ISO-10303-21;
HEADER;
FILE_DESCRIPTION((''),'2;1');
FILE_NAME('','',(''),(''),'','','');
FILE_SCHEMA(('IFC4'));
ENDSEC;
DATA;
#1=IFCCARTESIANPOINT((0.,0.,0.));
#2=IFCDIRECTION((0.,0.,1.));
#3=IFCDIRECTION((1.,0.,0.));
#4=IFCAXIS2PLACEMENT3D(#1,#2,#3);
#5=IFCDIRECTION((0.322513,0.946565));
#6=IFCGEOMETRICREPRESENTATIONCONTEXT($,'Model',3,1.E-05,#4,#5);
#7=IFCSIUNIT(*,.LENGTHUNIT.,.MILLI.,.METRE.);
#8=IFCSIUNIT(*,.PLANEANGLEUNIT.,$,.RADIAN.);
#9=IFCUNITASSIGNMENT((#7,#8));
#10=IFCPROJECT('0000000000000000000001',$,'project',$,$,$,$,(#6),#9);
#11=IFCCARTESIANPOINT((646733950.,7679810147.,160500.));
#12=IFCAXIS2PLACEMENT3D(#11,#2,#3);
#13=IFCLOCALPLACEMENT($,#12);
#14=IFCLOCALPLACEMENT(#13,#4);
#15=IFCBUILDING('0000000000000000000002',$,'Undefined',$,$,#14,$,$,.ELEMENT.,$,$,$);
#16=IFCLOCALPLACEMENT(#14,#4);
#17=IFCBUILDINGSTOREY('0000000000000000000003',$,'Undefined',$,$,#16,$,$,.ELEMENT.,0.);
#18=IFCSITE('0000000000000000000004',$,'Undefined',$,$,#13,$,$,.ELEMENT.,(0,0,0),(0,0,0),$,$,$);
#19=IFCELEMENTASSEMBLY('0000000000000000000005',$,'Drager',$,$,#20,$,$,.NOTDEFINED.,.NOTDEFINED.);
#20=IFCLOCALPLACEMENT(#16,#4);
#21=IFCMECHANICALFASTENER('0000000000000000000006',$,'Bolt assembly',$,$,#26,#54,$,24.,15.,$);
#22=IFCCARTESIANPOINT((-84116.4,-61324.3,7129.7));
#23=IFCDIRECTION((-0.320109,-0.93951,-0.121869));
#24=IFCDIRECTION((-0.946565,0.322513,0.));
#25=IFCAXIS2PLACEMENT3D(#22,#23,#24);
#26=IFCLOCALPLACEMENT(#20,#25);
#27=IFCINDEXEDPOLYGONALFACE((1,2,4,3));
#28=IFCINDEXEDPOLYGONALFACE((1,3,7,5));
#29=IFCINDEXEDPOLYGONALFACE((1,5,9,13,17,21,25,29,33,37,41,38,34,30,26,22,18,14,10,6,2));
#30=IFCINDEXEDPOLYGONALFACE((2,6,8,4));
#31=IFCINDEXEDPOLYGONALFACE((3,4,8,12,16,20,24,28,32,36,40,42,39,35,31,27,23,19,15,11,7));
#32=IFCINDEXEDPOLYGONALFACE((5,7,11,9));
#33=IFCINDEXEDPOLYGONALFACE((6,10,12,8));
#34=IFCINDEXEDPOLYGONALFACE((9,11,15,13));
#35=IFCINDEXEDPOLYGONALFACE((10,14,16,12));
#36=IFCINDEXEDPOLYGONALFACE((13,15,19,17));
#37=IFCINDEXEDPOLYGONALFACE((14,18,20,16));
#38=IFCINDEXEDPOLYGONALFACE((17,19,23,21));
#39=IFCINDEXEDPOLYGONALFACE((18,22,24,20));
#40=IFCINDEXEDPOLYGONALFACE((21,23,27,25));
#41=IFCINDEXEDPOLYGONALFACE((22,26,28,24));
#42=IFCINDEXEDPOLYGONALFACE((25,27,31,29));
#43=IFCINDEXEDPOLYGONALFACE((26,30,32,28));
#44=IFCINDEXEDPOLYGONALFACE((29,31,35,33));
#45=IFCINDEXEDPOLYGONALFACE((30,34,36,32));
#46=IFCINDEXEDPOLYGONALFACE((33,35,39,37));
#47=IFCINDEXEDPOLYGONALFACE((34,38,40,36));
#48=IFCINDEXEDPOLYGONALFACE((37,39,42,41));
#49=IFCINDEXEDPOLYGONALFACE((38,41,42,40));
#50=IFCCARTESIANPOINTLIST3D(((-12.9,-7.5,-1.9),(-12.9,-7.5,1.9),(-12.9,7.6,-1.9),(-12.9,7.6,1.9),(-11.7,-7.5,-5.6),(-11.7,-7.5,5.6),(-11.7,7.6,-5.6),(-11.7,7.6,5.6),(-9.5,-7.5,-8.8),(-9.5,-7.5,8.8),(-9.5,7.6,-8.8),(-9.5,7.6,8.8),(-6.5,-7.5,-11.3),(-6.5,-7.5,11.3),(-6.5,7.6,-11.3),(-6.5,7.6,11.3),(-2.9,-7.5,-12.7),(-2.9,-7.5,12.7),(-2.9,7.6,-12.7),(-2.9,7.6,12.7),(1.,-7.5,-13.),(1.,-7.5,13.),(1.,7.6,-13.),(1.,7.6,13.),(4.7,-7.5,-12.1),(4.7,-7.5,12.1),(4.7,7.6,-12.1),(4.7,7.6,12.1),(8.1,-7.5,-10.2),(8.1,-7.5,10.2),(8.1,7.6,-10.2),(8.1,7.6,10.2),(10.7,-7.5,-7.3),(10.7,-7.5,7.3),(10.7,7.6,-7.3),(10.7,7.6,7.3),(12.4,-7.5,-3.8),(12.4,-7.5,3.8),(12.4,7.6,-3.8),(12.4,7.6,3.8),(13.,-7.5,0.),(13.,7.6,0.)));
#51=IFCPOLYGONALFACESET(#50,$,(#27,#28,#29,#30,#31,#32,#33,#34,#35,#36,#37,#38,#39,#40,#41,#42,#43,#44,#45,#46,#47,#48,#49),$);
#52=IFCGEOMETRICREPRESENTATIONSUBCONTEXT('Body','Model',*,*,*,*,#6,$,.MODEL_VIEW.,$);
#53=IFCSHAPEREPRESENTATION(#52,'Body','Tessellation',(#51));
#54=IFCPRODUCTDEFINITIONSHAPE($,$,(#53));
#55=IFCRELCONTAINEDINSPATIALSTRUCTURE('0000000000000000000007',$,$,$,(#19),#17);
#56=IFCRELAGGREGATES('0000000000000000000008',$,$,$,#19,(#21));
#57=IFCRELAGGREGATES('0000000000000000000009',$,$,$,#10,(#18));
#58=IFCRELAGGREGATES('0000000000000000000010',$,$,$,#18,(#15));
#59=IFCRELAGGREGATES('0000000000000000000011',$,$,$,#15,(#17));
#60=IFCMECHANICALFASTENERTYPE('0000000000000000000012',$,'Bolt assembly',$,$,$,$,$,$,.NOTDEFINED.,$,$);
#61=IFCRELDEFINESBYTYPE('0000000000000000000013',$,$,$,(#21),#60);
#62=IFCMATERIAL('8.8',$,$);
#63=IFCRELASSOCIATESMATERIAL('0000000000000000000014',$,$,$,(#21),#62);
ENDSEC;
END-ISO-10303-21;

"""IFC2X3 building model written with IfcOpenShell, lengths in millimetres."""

from ifc_helpers import new_model, si_unit, direction, frame, origin_with_axes, origin_2d_with_axis, place, context, subcontext, project, spatial, circle, extrude, source, transform, mapped, material, type_object, element, aggregate, save


model = new_model("IFC2X3")

# Units and contexts
model_context = context("Model", 3, precision=1e-05, world=origin_with_axes(), true_north=direction((0.322513, 0.946565)))
body_context = subcontext(model_context, "Body", "Model", "MODEL_VIEW")
ifc_project = project(units=[si_unit("LENGTHUNIT", "METRE", prefix="MILLI"), si_unit("PLANEANGLEUNIT", "RADIAN")], contexts=[model_context])

# Site, building, storey
site_placement = place(None, frame((646733950.0, 7679810147.0, 160500.0), z_axis=(0.0, 0.0, 1.0), x_axis=(1.0, 0.0, 0.0)))
site = spatial("IfcSite", under=ifc_project, at=site_placement, Name="Undefined", CompositionType="ELEMENT", RefLatitude=(0, 0, 0), RefLongitude=(0, 0, 0))
building_placement = place(site_placement, origin_with_axes())
building = spatial("IfcBuilding", under=site, at=building_placement, Name="Undefined", CompositionType="ELEMENT")
storey_placement = place(building_placement, origin_with_axes())
storey = spatial("IfcBuildingStorey", under=building, at=storey_placement, Name="Undefined", CompositionType="ELEMENT", Elevation=0.0)

# Element assembly
assembly_1_placement = place(storey_placement, origin_with_axes())
assembly_1 = element("IfcElementAssembly", 1, at=assembly_1_placement, inside=storey, Name="Drager", AssemblyPlace="NOTDEFINED", PredefinedType="NOTDEFINED")

# Mechanical fastener
ifc_material_1 = material(Name="8.8")
mechanical_fastener_type = type_object("IfcMechanicalFastenerType", Name="Bolt assembly")
shared_shape_1 = source(origin_with_axes(), body_context, "Body", "SweptSolid", [
    extrude(circle(Radius=13.0, at=origin_2d_with_axis()), frame((0.0, -7.5, 0.0), z_axis=(0.0, 1.0, 0.0), x_axis=(1.0, 0.0, 0.0)), (0.0, 0.0, 1.0), 15.1),
])
mechanical_fastener_1_placement = place(assembly_1_placement, frame((-84116.4, -61324.3, 7129.7), z_axis=(-0.320109, -0.93951, -0.121869), x_axis=(-0.946565, 0.322513, 0.0)))
mechanical_fastener_1 = element("IfcMechanicalFastener", 2, at=mechanical_fastener_1_placement, type_object=mechanical_fastener_type, material=ifc_material_1, Name="Bolt assembly", NominalDiameter=24.0, NominalLength=15.0, context=body_context, shape_type="MappedRepresentation", body=[
    mapped(shared_shape_1, transform((0.0, 0.0, 0.0))),
])
aggregate(assembly_1, [mechanical_fastener_1])

save(model, "model.ifc")
